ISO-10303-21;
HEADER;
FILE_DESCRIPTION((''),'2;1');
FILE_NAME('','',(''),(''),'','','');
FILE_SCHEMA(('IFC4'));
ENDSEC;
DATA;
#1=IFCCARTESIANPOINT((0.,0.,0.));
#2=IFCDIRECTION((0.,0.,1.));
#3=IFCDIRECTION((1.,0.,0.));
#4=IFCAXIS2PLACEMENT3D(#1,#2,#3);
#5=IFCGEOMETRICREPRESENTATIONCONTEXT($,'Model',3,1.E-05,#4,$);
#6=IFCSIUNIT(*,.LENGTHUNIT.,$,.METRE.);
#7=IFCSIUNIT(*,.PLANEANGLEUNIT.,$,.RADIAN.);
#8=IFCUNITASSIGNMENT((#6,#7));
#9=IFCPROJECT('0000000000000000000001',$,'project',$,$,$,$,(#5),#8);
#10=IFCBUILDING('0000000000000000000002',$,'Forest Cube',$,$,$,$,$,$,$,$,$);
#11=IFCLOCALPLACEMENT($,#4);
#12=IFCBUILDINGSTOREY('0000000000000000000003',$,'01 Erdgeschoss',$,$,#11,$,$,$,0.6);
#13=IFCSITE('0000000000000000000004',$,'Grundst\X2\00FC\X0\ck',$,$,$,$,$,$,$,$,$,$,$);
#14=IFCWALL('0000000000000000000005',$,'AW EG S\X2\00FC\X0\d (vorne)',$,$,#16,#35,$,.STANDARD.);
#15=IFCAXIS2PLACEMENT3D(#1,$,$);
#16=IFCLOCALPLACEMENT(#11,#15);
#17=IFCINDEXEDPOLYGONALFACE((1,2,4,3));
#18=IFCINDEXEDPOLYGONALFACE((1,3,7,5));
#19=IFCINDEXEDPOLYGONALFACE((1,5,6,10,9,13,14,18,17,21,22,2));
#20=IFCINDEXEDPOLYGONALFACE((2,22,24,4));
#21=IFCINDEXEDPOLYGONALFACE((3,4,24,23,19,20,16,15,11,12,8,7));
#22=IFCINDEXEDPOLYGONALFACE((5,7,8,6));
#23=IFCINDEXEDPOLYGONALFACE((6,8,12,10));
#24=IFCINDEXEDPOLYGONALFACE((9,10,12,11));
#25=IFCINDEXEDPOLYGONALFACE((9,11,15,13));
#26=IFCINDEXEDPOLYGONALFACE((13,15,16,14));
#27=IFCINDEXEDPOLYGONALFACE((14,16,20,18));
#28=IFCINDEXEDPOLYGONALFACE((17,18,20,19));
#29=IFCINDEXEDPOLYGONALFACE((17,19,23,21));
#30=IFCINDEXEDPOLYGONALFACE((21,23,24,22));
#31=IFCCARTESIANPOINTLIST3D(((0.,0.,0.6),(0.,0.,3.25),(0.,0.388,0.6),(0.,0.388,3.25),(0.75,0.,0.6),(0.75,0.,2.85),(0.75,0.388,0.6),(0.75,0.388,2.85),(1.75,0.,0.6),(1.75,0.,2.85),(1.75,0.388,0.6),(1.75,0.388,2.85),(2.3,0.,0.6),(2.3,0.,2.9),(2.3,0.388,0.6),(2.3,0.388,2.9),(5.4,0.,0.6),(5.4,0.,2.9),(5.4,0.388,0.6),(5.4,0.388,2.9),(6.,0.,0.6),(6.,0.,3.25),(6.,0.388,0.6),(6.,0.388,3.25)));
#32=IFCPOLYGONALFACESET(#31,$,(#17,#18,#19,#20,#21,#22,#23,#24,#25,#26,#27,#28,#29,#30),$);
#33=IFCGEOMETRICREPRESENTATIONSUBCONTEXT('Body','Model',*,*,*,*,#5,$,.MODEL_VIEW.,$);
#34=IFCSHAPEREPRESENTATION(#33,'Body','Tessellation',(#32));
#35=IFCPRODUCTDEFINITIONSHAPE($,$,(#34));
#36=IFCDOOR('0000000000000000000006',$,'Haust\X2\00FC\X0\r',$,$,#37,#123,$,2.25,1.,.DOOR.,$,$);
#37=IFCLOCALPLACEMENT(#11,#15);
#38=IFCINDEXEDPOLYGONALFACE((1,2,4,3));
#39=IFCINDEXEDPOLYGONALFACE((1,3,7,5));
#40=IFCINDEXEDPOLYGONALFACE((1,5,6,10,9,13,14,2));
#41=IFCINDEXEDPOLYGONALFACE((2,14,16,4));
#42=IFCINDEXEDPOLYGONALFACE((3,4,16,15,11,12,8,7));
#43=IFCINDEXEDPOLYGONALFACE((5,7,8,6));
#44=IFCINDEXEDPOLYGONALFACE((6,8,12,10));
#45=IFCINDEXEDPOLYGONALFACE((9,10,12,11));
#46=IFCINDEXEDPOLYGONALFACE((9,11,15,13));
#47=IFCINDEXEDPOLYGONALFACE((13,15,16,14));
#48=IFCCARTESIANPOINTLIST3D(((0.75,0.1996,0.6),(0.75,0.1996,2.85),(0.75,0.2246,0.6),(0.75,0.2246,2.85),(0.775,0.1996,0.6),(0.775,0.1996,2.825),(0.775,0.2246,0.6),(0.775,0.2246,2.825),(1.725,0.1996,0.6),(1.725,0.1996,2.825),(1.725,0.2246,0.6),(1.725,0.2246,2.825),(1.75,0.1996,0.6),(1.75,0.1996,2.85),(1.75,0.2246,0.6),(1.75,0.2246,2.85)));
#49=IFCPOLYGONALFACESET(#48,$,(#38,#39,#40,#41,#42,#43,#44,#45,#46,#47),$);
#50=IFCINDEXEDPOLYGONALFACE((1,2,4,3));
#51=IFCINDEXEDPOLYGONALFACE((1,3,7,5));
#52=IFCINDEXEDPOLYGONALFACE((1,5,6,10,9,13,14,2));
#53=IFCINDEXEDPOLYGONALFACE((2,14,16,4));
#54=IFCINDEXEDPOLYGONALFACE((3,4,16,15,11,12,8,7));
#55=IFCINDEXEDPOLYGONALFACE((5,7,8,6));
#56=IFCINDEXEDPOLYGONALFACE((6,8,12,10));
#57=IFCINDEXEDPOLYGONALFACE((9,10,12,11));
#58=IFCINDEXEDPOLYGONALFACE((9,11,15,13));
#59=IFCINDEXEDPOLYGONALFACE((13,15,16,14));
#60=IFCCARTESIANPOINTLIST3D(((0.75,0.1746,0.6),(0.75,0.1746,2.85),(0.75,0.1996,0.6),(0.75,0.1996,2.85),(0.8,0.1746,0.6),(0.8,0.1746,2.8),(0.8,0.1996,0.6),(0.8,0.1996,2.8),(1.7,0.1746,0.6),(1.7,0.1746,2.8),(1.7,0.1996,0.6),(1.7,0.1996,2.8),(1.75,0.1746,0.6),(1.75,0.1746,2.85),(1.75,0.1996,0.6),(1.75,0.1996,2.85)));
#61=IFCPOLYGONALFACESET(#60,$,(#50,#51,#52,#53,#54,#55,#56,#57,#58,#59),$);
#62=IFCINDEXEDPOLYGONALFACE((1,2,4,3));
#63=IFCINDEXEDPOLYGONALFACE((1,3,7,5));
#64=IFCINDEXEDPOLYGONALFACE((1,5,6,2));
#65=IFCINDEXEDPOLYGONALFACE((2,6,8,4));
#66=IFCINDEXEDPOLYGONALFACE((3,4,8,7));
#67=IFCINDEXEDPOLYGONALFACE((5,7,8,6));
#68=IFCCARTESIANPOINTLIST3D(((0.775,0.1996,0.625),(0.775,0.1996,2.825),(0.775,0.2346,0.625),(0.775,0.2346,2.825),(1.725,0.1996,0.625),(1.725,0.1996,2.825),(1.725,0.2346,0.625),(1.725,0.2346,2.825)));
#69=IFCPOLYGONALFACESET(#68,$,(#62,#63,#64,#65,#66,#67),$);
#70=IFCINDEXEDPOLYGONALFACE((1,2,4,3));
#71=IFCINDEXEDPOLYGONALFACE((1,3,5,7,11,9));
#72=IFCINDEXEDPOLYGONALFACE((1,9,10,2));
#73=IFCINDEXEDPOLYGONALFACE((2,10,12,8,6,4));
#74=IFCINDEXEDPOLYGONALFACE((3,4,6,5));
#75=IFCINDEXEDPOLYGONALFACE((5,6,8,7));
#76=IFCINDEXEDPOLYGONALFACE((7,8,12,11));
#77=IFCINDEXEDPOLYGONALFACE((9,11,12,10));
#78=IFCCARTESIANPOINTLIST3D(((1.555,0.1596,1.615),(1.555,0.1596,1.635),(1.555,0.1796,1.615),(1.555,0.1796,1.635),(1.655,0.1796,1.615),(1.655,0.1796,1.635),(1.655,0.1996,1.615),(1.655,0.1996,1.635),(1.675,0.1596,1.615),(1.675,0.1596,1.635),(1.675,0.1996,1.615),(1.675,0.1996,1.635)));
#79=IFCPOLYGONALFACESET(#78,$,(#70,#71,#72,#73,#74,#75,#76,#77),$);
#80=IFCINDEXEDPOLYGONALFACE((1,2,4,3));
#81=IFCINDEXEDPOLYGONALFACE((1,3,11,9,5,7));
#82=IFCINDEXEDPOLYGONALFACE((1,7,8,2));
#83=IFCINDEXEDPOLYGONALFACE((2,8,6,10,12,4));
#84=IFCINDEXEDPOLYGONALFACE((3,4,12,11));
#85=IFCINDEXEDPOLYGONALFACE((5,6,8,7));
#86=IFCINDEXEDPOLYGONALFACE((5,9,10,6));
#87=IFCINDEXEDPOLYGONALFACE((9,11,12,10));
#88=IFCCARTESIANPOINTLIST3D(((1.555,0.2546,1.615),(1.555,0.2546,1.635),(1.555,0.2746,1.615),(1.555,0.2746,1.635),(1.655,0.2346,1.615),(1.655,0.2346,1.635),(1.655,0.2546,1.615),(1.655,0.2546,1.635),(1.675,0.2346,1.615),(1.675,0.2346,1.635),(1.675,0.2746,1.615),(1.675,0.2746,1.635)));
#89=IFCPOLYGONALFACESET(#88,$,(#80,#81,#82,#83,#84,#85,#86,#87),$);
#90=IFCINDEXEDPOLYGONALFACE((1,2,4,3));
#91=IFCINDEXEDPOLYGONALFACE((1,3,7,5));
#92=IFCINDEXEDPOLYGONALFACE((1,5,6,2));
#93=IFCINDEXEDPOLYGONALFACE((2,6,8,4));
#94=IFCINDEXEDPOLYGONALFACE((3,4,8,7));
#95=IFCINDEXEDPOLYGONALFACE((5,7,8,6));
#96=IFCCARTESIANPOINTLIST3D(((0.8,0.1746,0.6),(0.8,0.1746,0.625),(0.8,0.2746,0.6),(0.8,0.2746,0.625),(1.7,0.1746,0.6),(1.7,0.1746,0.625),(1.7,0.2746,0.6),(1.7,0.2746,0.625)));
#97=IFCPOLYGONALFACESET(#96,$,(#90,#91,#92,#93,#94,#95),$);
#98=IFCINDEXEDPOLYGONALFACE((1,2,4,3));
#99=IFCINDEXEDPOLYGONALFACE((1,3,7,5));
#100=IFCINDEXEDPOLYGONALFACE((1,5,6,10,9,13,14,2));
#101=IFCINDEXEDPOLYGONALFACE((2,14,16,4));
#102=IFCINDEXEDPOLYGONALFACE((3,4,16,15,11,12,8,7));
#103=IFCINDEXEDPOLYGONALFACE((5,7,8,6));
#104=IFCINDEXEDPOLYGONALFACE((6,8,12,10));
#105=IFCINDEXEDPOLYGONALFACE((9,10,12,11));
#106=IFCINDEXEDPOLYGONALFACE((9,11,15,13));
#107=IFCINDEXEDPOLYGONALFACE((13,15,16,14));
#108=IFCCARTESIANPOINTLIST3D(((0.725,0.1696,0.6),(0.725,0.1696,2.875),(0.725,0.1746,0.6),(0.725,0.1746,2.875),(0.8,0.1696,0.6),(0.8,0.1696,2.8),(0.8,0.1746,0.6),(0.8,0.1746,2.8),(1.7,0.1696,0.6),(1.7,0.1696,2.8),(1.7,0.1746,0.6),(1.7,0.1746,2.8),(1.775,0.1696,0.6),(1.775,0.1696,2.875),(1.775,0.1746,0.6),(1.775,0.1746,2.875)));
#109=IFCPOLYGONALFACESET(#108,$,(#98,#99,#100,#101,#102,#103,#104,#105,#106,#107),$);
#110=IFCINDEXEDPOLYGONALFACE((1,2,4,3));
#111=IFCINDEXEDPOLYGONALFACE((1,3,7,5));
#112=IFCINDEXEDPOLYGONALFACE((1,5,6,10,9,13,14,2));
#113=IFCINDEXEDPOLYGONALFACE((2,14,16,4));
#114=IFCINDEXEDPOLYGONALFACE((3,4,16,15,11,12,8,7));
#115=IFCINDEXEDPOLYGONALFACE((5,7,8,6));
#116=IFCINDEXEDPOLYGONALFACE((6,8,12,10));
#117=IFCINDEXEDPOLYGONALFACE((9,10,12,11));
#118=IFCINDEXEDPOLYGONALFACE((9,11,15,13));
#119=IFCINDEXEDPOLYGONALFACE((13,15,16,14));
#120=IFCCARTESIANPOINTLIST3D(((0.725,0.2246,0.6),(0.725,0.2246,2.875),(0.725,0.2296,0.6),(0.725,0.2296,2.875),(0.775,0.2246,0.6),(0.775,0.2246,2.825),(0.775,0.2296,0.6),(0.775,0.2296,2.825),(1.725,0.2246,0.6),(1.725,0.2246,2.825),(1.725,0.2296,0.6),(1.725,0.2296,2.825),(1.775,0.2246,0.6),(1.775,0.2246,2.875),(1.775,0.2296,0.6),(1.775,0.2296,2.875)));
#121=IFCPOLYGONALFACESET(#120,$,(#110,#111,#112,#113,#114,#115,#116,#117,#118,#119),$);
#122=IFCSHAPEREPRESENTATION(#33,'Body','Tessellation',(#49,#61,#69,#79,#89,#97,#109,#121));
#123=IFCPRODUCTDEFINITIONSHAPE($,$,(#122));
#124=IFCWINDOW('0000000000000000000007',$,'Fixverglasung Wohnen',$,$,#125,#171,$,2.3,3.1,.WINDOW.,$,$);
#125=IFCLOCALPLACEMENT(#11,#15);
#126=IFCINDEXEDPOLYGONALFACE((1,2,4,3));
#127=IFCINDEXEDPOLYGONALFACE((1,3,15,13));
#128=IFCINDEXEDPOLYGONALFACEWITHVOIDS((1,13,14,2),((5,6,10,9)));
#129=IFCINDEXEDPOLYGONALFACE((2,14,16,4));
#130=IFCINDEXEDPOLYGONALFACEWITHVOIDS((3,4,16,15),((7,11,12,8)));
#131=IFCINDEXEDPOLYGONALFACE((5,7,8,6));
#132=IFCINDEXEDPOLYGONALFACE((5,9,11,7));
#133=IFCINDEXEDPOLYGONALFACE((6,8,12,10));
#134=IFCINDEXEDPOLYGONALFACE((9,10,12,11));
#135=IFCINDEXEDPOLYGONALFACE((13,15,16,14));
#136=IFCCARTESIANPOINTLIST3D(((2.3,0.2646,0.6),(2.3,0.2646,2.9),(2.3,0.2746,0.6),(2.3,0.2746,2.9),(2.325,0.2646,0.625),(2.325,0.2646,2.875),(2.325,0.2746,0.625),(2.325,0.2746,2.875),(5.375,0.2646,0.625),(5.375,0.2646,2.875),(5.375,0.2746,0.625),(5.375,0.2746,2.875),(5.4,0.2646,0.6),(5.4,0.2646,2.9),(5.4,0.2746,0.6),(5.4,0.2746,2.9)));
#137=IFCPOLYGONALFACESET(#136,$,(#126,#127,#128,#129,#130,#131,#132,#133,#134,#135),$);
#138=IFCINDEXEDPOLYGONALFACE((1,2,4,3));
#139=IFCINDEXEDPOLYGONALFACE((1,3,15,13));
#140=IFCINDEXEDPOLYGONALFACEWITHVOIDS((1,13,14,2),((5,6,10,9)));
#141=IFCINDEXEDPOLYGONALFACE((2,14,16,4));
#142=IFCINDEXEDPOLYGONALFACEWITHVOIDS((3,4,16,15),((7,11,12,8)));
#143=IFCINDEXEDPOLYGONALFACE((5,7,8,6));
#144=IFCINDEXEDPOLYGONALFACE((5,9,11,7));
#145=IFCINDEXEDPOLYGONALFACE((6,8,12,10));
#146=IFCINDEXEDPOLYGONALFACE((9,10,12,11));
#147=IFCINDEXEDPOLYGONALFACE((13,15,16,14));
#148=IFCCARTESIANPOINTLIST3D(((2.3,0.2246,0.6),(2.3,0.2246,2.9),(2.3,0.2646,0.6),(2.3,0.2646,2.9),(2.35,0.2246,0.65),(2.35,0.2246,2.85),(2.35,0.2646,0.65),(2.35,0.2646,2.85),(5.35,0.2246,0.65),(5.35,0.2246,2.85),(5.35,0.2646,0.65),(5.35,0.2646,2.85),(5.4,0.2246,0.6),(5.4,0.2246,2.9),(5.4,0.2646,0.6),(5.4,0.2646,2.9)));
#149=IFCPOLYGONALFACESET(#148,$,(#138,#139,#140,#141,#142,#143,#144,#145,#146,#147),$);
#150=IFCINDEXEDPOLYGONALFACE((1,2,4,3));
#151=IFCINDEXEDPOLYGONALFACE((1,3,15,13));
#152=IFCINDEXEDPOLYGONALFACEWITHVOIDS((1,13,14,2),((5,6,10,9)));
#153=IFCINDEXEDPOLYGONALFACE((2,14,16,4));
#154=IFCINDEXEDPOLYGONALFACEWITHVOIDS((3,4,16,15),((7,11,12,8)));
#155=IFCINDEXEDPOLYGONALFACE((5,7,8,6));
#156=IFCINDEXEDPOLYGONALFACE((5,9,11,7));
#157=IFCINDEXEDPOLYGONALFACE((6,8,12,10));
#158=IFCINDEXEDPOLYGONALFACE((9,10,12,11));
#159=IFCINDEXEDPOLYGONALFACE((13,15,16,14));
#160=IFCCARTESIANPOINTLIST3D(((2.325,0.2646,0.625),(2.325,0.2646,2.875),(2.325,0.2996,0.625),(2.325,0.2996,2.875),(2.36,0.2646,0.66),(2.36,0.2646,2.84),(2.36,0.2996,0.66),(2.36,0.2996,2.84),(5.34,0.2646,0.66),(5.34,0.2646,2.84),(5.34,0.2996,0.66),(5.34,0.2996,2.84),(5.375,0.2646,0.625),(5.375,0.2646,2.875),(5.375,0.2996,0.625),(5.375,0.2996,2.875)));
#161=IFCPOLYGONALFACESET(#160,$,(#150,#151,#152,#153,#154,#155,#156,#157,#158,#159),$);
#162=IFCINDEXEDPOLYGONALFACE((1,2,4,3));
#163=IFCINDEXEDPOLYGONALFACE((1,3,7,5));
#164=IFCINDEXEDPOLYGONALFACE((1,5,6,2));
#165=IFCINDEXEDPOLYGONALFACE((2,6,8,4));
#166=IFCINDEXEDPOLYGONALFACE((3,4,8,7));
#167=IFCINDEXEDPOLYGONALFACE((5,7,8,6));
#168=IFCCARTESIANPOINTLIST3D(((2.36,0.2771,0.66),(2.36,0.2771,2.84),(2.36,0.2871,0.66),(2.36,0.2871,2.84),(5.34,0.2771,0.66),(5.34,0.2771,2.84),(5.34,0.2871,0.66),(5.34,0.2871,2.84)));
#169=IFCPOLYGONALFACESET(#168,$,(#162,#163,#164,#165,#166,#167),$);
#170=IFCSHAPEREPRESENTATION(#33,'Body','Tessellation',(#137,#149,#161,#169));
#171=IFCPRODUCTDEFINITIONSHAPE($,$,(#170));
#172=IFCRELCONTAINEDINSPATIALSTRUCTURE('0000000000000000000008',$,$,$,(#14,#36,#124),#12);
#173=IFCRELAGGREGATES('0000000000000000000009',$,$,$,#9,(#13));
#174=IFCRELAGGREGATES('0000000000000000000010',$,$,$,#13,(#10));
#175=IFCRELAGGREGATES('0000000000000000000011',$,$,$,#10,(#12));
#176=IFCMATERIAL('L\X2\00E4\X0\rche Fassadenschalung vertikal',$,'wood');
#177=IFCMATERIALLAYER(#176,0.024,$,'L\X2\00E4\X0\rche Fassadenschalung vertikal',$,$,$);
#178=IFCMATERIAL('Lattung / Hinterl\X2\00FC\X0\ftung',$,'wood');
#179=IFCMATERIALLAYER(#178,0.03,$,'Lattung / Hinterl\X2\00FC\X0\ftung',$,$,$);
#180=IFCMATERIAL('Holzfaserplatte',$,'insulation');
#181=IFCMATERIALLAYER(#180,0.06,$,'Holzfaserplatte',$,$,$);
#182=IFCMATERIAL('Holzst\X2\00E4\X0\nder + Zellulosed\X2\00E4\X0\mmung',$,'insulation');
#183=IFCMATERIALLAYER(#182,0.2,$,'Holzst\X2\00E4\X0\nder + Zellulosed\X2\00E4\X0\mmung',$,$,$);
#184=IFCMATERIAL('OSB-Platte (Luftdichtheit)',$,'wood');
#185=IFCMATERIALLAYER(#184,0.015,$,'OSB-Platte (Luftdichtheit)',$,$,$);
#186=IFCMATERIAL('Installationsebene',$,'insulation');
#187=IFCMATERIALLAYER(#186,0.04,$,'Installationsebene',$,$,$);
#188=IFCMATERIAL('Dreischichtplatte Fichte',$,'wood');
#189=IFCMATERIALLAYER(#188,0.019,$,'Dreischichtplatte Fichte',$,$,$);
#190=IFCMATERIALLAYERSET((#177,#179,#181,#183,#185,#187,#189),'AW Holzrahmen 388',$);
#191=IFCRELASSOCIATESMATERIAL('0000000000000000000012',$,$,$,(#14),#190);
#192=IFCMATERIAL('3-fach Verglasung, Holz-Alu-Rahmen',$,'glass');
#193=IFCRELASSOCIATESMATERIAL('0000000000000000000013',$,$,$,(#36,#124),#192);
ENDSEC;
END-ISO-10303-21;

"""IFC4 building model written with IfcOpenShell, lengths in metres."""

from ifc_helpers import new_model, si_unit, frame, origin_with_axes, place, context, subcontext, project, spatial, line, indexed_curve, outline, extrude, material, layer, layer_set, element, fill, save


model = new_model("IFC4")

# Units and contexts
model_context = context("Model", 3, precision=1e-05, world=origin_with_axes())
body_context = subcontext(model_context, "Body", "Model", "MODEL_VIEW")
ifc_project = project(units=[si_unit("LENGTHUNIT", "METRE"), si_unit("PLANEANGLEUNIT", "RADIAN")], contexts=[model_context])

# Site, building, storey
site = spatial("IfcSite", under=ifc_project, Name="Grundstück")
building = spatial("IfcBuilding", under=site, Name="Forest Cube")
storey_placement = place(None, origin_with_axes())
storey = spatial("IfcBuildingStorey", under=building, at=storey_placement, Name="01 Erdgeschoss", Elevation=0.6)

# Wall, openings, door, window
ifc_material_1 = material(Name="Lärche Fassadenschalung vertikal", Category="wood")
ifc_layer_1 = layer(ifc_material_1, 0.024, Name="Lärche Fassadenschalung vertikal")
ifc_material_2 = material(Name="Lattung / Hinterlüftung", Category="wood")
ifc_layer_2 = layer(ifc_material_2, 0.03, Name="Lattung / Hinterlüftung")
ifc_material_3 = material(Name="Holzfaserplatte", Category="insulation")
ifc_layer_3 = layer(ifc_material_3, 0.06, Name="Holzfaserplatte")
ifc_material_4 = material(Name="Holzständer + Zellulosedämmung", Category="insulation")
ifc_layer_4 = layer(ifc_material_4, 0.2, Name="Holzständer + Zellulosedämmung")
ifc_material_5 = material(Name="OSB-Platte (Luftdichtheit)", Category="wood")
ifc_layer_5 = layer(ifc_material_5, 0.015, Name="OSB-Platte (Luftdichtheit)")
ifc_material_6 = material(Name="Installationsebene", Category="insulation")
ifc_layer_6 = layer(ifc_material_6, 0.04, Name="Installationsebene")
ifc_material_7 = material(Name="Dreischichtplatte Fichte", Category="wood")
ifc_layer_7 = layer(ifc_material_7, 0.019, Name="Dreischichtplatte Fichte")
ifc_layer_set_1 = layer_set([ifc_layer_1, ifc_layer_2, ifc_layer_3, ifc_layer_4, ifc_layer_5, ifc_layer_6, ifc_layer_7], Name="AW Holzrahmen 388")
wall_1_placement = place(storey_placement, frame((0.0, 0.0, 0.6), z_axis=(0.0, 0.0, 1.0), x_axis=(1.0, 0.0, 0.0)))
wall_1 = element("IfcWall", 1, at=wall_1_placement, inside=storey, material=ifc_layer_set_1, Name="AW EG Süd (vorne)", PredefinedType="STANDARD", context=body_context, shape_type="SweptSolid", body=[
    extrude(outline(indexed_curve([(0.0, 0.0), (0.0, 0.388), (6.0, 0.388), (6.0, 0.0), (0.0, 0.0)], self_intersect=False)), origin_with_axes(), (0.0, 0.0, 1.0), 2.65),
])
opening_1_placement = place(wall_1_placement, frame((0.75, -0.1, 0.0), z_axis=(0.0, 0.0, 1.0), x_axis=(1.0, 0.0, 0.0)))
opening_1 = element("IfcOpeningElement", 2, at=opening_1_placement, cuts=wall_1, context=body_context, shape_type="SweptSolid", body=[
    extrude(outline(indexed_curve([(0.0, 0.0), (0.0, 0.588), (1.0, 0.588), (1.0, 0.0), (0.0, 0.0)], self_intersect=False)), origin_with_axes(), (0.0, 0.0, 1.0), 2.25),
])
opening_2_placement = place(wall_1_placement, frame((2.3, -0.1, 0.0), z_axis=(0.0, 0.0, 1.0), x_axis=(1.0, 0.0, 0.0)))
opening_2 = element("IfcOpeningElement", 3, at=opening_2_placement, cuts=wall_1, context=body_context, shape_type="SweptSolid", body=[
    extrude(outline(indexed_curve([(0.0, 0.0), (0.0, 0.588), (3.1, 0.588), (3.1, 0.0), (0.0, 0.0)], self_intersect=False)), origin_with_axes(), (0.0, 0.0, 1.0), 2.3),
])
ifc_material_8 = material(Name="3-fach Verglasung, Holz-Alu-Rahmen", Category="glass")
door_placement = place(storey_placement, frame((0.75, 0.1746, 0.6), z_axis=(0.0, 0.0, 1.0), x_axis=(1.0, 0.0, 0.0)))
door = element("IfcDoor", 4, at=door_placement, inside=storey, material=ifc_material_8, Name="Haustür", OverallHeight=2.25, OverallWidth=1.0, PredefinedType="DOOR", context=body_context, shape_type="SweptSolid", body=[
    extrude(outline(indexed_curve([(0.0, 0.0), (0.0, 2.25), (1.0, 2.25), (1.0, 0.0), (0.975, 0.0), (0.975, 2.225), (0.025, 2.225), (0.025, 0.0)], segments=[line(1, 2, 3, 4, 5, 6, 7, 8, 1)])), frame((0.0, 0.025, 0.0), z_axis=(0.0, -1.0, 0.0), x_axis=(1.0, 0.0, 0.0)), (0.0, 0.0, -1.0), 0.025),
    extrude(outline(indexed_curve([(0.0, 0.0), (0.0, 2.25), (1.0, 2.25), (1.0, 0.0), (0.95, 0.0), (0.95, 2.2), (0.05, 2.2), (0.05, 0.0)], segments=[line(1, 2, 3, 4, 5, 6, 7, 8, 1)])), frame((0.0, 0.0, 0.0), z_axis=(0.0, -1.0, 0.0), x_axis=(1.0, 0.0, 0.0)), (0.0, 0.0, -1.0), 0.025),
    extrude(outline(indexed_curve([(0.0, 0.0), (0.95, 0.0), (0.95, 0.035), (0.0, 0.035)], segments=[line(1, 2, 3, 4, 1)])), frame((0.025, 0.025, 0.025), z_axis=(0.0, 0.0, 1.0), x_axis=(1.0, 0.0, 0.0)), (0.0, 0.0, 1.0), 2.2),
    extrude(outline(indexed_curve([(0.0, 0.0), (0.0, -0.04), (-0.12, -0.04), (-0.12, -0.02), (-0.02, -0.02), (-0.02, 0.0)], segments=[line(1, 2, 3, 4, 5, 6, 1)])), frame((0.925, 0.025, 1.015), z_axis=(0.0, 0.0, 1.0), x_axis=(1.0, 0.0, 0.0)), (0.0, 0.0, 1.0), 0.02),
    extrude(outline(indexed_curve([(0.0, 0.0), (0.0, 0.04), (-0.12, 0.04), (-0.12, 0.02), (-0.02, 0.02), (-0.02, 0.0)], segments=[line(1, 2, 3, 4, 5, 6, 1)])), frame((0.925, 0.06, 1.015), z_axis=(0.0, 0.0, 1.0), x_axis=(1.0, 0.0, 0.0)), (0.0, 0.0, 1.0), 0.02),
    extrude(outline(indexed_curve([(0.0, 0.0), (0.9, 0.0), (0.9, 0.1), (0.0, 0.1)], segments=[line(1, 2, 3, 4, 1)])), frame((0.05, 0.0, 0.0), z_axis=(0.0, 0.0, 1.0), x_axis=(1.0, 0.0, 0.0)), (0.0, 0.0, 1.0), 0.025),
    extrude(outline(indexed_curve([(0.0, 0.0), (0.0, 2.275), (1.05, 2.275), (1.05, 0.0), (0.975, 0.0), (0.975, 2.2), (0.075, 2.2), (0.075, 0.0)], segments=[line(1, 2, 3, 4, 5, 6, 7, 8, 1)])), frame((-0.025, -0.005, 0.0), z_axis=(0.0, -1.0, 0.0), x_axis=(1.0, 0.0, 0.0)), (0.0, 0.0, -1.0), 0.005),
    extrude(outline(indexed_curve([(0.0, 0.0), (0.0, 2.275), (1.05, 2.275), (1.05, 0.0), (1.0, 0.0), (1.0, 2.225), (0.05, 2.225), (0.05, 0.0)], segments=[line(1, 2, 3, 4, 5, 6, 7, 8, 1)])), frame((-0.025, 0.05, 0.0), z_axis=(0.0, -1.0, 0.0), x_axis=(1.0, 0.0, 0.0)), (0.0, 0.0, -1.0), 0.005),
])
fill(opening_1, door)
window_1_placement = place(storey_placement, frame((2.3, 0.1746, 0.6), z_axis=(0.0, 0.0, 1.0), x_axis=(1.0, 0.0, 0.0)))
window_1 = element("IfcWindow", 5, at=window_1_placement, inside=storey, material=ifc_material_8, Name="Fixverglasung Wohnen", OverallHeight=2.3, OverallWidth=3.1, PredefinedType="WINDOW", context=body_context, shape_type="SweptSolid", body=[
    extrude(outline(indexed_curve([(0.0, 0.0), (3.1, 0.0), (3.1, 2.3), (0.0, 2.3)], segments=[line(1, 2, 3, 4, 1)]), holes=[indexed_curve([(0.025, 0.025), (3.075, 0.025), (3.075, 2.275), (0.025, 2.275)], segments=[line(1, 2, 3, 4, 1)])]), frame((0.0, 0.09, 0.0), z_axis=(0.0, -1.0, 0.0), x_axis=(1.0, 0.0, 0.0)), (0.0, 0.0, -1.0), 0.01),
    extrude(outline(indexed_curve([(0.0, 0.0), (3.1, 0.0), (3.1, 2.3), (0.0, 2.3)], segments=[line(1, 2, 3, 4, 1)]), holes=[indexed_curve([(0.05, 0.05), (3.05, 0.05), (3.05, 2.25), (0.05, 2.25)], segments=[line(1, 2, 3, 4, 1)])]), frame((0.0, 0.05, 0.0), z_axis=(0.0, -1.0, 0.0), x_axis=(1.0, 0.0, 0.0)), (0.0, 0.0, -1.0), 0.04),
    extrude(outline(indexed_curve([(0.0, 0.0), (3.05, 0.0), (3.05, 2.25), (0.0, 2.25)], segments=[line(1, 2, 3, 4, 1)]), holes=[indexed_curve([(0.035, 0.035), (3.015, 0.035), (3.015, 2.215), (0.035, 2.215)], segments=[line(1, 2, 3, 4, 1)])]), frame((0.025, 0.09, 0.025), z_axis=(0.0, -1.0, 0.0), x_axis=(1.0, 0.0, 0.0)), (0.0, 0.0, -1.0), 0.035),
    extrude(outline(indexed_curve([(0.035, 0.035), (3.015, 0.035), (3.015, 2.215), (0.035, 2.215)], segments=[line(1, 2, 3, 4, 1)])), frame((0.025, 0.1025, 0.025), z_axis=(0.0, -1.0, 0.0), x_axis=(1.0, 0.0, 0.0)), (0.0, 0.0, -1.0), 0.01),
])
fill(opening_2, window_1)

save(model, "model.ifc")
